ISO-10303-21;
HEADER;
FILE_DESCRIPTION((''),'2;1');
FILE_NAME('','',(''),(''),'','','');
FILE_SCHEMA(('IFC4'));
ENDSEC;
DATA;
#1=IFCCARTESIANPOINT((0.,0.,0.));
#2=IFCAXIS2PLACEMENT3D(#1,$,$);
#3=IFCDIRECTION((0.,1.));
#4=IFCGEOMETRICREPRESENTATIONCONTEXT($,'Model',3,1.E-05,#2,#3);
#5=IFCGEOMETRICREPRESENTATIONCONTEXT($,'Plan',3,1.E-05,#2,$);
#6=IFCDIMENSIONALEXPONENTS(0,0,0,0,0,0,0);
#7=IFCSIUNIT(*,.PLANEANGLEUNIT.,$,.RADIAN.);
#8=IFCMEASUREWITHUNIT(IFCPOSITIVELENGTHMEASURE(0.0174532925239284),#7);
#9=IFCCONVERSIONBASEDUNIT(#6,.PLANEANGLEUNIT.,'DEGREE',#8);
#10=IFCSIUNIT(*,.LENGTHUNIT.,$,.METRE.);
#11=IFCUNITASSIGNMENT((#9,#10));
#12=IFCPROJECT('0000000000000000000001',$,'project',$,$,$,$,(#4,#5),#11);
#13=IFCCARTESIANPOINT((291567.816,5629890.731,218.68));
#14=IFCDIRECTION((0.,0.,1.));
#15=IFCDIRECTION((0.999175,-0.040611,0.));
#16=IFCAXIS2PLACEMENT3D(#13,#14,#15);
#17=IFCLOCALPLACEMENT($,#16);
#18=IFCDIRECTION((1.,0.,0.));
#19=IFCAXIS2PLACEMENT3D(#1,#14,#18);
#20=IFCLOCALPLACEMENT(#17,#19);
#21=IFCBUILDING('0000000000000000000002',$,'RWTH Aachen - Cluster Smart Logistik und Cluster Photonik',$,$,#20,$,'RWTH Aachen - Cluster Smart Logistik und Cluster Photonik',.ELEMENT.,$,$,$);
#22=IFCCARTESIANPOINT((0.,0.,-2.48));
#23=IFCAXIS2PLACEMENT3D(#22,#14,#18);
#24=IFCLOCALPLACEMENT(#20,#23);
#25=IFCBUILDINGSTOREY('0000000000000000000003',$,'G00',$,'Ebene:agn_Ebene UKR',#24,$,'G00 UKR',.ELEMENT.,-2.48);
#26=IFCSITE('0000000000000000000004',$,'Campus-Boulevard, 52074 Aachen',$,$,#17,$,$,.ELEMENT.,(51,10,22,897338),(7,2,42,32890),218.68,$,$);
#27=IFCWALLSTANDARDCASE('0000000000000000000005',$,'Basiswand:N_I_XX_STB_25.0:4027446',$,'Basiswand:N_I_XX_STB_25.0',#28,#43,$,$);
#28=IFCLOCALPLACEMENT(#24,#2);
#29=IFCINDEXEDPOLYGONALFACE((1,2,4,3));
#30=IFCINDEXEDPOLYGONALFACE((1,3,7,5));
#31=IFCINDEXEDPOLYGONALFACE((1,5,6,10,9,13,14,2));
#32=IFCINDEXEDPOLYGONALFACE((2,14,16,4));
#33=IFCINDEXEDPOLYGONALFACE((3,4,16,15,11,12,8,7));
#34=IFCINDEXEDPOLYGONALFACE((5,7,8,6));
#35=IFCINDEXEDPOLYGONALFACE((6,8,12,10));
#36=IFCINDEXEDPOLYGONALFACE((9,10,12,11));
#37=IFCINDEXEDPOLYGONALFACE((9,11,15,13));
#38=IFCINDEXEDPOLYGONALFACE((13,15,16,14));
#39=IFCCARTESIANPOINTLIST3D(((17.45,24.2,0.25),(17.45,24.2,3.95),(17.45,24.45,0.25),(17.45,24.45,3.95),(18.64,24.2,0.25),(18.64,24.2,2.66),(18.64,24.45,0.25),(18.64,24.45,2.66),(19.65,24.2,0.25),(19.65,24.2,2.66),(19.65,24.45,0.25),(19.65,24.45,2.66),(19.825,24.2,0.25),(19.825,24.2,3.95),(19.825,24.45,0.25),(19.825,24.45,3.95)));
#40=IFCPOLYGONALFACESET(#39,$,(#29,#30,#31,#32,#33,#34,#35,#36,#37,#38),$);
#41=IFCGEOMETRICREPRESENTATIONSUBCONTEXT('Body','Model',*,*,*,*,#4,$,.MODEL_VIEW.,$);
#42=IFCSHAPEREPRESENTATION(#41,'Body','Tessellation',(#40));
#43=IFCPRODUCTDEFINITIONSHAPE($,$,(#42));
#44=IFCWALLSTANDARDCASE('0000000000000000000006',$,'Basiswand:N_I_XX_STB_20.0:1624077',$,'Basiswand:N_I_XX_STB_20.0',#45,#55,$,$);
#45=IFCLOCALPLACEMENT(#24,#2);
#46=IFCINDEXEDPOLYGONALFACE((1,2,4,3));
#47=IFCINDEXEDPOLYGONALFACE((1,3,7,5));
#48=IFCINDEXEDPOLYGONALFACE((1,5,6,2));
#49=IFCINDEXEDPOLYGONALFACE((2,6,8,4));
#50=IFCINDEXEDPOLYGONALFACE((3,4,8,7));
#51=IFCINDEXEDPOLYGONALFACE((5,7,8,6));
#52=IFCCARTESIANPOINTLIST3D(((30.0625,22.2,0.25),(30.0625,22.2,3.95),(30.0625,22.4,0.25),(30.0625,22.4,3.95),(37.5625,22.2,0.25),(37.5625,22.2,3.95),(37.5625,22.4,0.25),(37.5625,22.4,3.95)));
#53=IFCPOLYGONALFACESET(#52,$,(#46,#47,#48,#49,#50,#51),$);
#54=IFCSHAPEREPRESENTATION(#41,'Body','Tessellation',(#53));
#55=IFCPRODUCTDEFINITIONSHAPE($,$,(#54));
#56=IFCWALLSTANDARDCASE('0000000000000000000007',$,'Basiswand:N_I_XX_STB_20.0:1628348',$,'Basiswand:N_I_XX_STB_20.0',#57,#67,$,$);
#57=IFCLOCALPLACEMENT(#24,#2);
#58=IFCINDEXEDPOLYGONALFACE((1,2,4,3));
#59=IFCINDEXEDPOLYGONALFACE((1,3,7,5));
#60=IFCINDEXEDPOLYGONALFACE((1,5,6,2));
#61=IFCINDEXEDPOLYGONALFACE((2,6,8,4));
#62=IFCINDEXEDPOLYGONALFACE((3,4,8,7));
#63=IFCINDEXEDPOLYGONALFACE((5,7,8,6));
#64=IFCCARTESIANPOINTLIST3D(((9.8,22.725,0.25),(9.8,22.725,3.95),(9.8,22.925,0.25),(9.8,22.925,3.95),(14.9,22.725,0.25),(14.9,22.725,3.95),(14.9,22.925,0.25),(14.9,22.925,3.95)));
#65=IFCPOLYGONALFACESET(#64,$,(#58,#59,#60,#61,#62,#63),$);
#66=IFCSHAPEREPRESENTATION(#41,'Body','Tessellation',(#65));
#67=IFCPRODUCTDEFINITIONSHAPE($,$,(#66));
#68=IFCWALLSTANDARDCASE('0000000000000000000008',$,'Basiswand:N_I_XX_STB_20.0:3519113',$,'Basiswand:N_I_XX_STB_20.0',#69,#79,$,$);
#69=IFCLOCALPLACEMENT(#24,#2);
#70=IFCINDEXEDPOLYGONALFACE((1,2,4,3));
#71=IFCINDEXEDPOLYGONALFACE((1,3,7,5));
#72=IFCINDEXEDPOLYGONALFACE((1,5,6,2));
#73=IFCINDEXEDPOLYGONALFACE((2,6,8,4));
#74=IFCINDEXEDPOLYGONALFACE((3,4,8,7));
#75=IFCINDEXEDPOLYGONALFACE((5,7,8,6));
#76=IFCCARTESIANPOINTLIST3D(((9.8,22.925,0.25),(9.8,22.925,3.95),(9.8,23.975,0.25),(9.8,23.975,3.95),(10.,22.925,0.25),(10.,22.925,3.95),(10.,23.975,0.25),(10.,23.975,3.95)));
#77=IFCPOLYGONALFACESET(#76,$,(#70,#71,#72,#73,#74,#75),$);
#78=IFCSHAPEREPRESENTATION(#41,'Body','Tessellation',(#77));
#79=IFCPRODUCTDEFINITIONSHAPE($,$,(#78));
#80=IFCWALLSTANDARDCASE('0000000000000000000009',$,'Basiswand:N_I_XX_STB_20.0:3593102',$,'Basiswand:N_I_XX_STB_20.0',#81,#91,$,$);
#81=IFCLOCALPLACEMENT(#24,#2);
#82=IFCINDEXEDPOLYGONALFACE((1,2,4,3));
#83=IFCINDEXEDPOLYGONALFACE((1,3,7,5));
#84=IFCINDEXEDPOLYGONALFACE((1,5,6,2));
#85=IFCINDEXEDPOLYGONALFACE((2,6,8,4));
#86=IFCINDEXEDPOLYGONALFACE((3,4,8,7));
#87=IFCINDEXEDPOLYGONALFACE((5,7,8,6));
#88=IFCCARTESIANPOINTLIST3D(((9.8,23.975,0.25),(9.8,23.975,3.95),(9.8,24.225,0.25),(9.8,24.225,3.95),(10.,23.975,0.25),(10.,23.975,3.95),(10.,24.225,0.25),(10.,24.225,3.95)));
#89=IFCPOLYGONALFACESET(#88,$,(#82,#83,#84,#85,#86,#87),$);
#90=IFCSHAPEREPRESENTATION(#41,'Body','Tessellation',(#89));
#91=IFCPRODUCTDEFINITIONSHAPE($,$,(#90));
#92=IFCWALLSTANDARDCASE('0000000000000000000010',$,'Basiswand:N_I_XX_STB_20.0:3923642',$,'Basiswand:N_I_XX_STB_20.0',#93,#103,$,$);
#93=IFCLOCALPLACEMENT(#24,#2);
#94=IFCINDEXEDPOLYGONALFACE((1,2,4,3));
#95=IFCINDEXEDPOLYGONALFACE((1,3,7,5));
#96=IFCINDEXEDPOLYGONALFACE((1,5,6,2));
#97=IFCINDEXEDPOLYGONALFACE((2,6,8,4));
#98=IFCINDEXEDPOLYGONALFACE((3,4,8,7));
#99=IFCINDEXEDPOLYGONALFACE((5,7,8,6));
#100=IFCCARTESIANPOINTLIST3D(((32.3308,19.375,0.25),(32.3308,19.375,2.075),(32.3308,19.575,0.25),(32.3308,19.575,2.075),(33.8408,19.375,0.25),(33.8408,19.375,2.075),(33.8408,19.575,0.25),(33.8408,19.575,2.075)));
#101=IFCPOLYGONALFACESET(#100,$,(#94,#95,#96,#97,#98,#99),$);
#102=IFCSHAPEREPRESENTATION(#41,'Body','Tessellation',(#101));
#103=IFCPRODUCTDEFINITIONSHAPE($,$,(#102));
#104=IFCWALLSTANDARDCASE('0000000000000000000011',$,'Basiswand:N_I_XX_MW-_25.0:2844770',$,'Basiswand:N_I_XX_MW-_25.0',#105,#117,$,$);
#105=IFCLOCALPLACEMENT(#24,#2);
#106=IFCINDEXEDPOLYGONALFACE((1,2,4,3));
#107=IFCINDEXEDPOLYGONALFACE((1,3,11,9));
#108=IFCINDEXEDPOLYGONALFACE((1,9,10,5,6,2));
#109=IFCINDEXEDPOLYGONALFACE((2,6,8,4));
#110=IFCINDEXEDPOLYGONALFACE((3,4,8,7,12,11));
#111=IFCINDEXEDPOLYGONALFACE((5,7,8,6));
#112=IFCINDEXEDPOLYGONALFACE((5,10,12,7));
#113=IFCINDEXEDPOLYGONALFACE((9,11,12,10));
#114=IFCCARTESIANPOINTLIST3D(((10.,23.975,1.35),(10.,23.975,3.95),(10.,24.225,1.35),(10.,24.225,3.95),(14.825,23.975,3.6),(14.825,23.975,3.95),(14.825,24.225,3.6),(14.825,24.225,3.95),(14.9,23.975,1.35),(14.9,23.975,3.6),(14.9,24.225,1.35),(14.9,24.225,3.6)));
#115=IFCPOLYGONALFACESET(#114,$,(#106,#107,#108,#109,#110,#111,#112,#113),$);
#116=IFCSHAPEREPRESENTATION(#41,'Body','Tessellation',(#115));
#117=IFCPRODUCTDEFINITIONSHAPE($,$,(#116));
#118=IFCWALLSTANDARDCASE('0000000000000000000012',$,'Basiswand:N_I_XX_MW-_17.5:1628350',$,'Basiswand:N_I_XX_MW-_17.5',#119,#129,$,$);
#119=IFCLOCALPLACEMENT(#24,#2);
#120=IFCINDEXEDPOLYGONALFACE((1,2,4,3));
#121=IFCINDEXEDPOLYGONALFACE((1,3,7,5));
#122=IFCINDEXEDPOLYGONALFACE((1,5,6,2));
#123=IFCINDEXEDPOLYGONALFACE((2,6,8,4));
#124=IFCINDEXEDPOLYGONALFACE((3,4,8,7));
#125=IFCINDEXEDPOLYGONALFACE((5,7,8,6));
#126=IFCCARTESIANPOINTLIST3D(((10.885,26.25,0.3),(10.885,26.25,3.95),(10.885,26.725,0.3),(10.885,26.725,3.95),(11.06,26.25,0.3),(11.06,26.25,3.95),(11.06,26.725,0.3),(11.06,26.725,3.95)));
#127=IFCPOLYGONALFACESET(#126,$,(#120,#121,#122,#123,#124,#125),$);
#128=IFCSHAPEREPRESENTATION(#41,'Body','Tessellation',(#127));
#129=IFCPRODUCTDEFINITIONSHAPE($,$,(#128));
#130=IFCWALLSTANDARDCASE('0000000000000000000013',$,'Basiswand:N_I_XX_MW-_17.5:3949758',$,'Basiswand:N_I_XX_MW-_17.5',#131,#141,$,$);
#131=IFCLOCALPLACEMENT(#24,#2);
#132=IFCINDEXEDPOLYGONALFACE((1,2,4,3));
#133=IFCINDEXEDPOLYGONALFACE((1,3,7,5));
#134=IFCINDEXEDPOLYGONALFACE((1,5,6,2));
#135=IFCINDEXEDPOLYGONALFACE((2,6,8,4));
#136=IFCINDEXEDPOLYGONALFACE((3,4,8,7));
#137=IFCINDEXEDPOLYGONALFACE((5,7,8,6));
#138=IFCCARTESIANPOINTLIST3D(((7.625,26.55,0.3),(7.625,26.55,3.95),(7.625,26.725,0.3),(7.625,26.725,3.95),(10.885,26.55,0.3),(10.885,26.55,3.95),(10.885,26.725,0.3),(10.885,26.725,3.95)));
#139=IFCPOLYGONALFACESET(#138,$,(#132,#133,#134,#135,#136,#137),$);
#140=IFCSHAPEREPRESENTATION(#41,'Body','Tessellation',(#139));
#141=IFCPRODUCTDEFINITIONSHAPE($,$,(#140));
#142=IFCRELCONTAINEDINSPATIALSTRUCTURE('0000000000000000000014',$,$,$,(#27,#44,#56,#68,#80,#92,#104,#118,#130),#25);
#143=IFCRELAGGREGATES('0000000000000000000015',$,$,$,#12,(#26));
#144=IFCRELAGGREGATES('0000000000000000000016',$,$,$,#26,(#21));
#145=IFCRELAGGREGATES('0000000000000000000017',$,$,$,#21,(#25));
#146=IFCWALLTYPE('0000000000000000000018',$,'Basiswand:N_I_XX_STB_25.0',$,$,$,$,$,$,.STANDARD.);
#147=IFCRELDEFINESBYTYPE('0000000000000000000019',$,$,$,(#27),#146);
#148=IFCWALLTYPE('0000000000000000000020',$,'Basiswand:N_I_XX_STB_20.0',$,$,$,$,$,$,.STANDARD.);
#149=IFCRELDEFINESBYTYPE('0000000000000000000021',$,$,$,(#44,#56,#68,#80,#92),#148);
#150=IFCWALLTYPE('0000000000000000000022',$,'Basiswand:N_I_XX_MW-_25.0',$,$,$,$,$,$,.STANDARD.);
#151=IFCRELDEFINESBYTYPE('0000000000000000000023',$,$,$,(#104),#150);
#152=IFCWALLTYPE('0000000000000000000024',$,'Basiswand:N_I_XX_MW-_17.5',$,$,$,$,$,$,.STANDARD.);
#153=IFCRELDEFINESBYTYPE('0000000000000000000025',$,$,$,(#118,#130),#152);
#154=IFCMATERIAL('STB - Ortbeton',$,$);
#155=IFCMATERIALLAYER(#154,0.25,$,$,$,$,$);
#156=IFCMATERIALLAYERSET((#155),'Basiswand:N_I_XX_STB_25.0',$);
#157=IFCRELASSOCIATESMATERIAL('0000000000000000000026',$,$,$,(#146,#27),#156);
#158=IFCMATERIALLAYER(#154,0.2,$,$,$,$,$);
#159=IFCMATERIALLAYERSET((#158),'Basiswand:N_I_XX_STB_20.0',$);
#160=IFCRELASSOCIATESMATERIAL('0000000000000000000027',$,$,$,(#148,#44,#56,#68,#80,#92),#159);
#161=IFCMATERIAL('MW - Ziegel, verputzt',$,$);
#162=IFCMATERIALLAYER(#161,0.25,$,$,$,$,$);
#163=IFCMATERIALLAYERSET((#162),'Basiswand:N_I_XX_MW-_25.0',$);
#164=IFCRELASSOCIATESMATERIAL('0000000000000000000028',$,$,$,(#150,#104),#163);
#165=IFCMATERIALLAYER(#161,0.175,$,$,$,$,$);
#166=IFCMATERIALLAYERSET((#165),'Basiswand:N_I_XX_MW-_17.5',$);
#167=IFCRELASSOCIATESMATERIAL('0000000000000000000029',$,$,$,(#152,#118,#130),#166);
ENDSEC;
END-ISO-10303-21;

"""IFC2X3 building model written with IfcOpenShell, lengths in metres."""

from ifc_helpers import new_model, entity, si_unit, converted_unit, direction, frame, frame_2d, origin, origin_with_axes, place, context, subcontext, project, spatial, polyline, rectangle, extrude, clip, bounded_halfspace, material, layer, layer_set, layer_usage, type_object, element, save


model = new_model("IFC2X3")

# Units and contexts
model_context = context("Model", 3, precision=1e-05, world=origin(), true_north=direction((0.0, 1.0)))
plan_context = context("Plan", 3, precision=1e-05, world=origin())
body_context = subcontext(model_context, "Body", "Model", "MODEL_VIEW")
ifc_project = project(units=[converted_unit("PLANEANGLEUNIT", "DEGREE", entity("IfcPositiveLengthMeasure", 0.0174532925239284), si_unit("PLANEANGLEUNIT", "RADIAN"), dimensions=[0, 0, 0, 0, 0, 0, 0]), si_unit("LENGTHUNIT", "METRE")], contexts=[model_context, plan_context])

# Site, building, storey
site_placement = place(None, frame((291567.816, 5629890.731, 218.68), z_axis=(0.0, 0.0, 1.0), x_axis=(0.999175, -0.040611, 0.0)))
site = spatial("IfcSite", under=ifc_project, at=site_placement, Name="Campus-Boulevard, 52074 Aachen", CompositionType="ELEMENT", RefLatitude=(51, 10, 22, 897338), RefLongitude=(7, 2, 42, 32890), RefElevation=218.68)
building_placement = place(site_placement, origin_with_axes())
building = spatial("IfcBuilding", under=site, at=building_placement, Name="RWTH Aachen - Cluster Smart Logistik und Cluster Photonik", LongName="RWTH Aachen - Cluster Smart Logistik und Cluster Photonik", CompositionType="ELEMENT")
storey_placement = place(building_placement, frame((0.0, 0.0, -2.48), z_axis=(0.0, 0.0, 1.0), x_axis=(1.0, 0.0, 0.0)))
storey = spatial("IfcBuildingStorey", under=building, at=storey_placement, Name="G00", ObjectType="Ebene:agn_Ebene UKR", LongName="G00 UKR", CompositionType="ELEMENT", Elevation=-2.48)

# Shared definitions
ifc_material_1 = material(Name="STB - Ortbeton")

# Shared definitions
ifc_layer_1 = layer(ifc_material_1, 0.25)
ifc_layer_set_1 = layer_set([ifc_layer_1], Name="Basiswand:N_I_XX_STB_25.0")
wall_type_1 = type_object("IfcWallType", Name="Basiswand:N_I_XX_STB_25.0", PredefinedType="STANDARD", material=ifc_layer_set_1)

# Wall, opening
ifc_layer_usage_1 = layer_usage(ifc_layer_set_1, "AXIS2", "NEGATIVE", 0.125)
wall_1_placement = place(storey_placement, frame((19.825, 24.325, 0.25), z_axis=(0.0, 0.0, 1.0), x_axis=(-1.0, 0.0, 0.0)))
wall_1 = element("IfcWallStandardCase", 1, at=wall_1_placement, inside=storey, type_object=wall_type_1, material=ifc_layer_usage_1, Name="Basiswand:N_I_XX_STB_25.0:4027446", ObjectType="Basiswand:N_I_XX_STB_25.0", context=body_context, shape_type="SweptSolid", body=[
    extrude(rectangle(XDim=2.375, YDim=0.25, at=frame_2d((1.1875, 0.0), x_axis=(-1.0, 0.0))), origin(), (0.0, 0.0, 1.0), 3.7),
])
opening_1_placement = place(wall_1_placement, frame((0.175, -0.125, 0.0), z_axis=(0.0, 0.0, 1.0), x_axis=(1.0, 0.0, 0.0)))
element("IfcOpeningElement", 2, at=opening_1_placement, cuts=wall_1, ObjectType="Opening", context=body_context, shape_type="SweptSolid", body=[
    extrude(rectangle(XDim=2.41, YDim=1.01, at=frame_2d((1.205, 0.505), x_axis=(1.0, 0.0))), frame((0.0, 0.0, 0.0), z_axis=(0.0, 1.0, 0.0), x_axis=(0.0, 0.0, 1.0)), (0.0, 0.0, 1.0), 0.25),
])

# Walls
ifc_layer_2 = layer(ifc_material_1, 0.2)
ifc_layer_set_2 = layer_set([ifc_layer_2], Name="Basiswand:N_I_XX_STB_20.0")
ifc_layer_usage_2 = layer_usage(ifc_layer_set_2, "AXIS2", "NEGATIVE", 0.1)
wall_type_2 = type_object("IfcWallType", Name="Basiswand:N_I_XX_STB_20.0", PredefinedType="STANDARD", material=ifc_layer_set_2)
wall_2_placement = place(storey_placement, frame((30.0625, 22.3, 0.25), z_axis=(0.0, 0.0, 1.0), x_axis=(1.0, 0.0, 0.0)))
element("IfcWallStandardCase", 3, at=wall_2_placement, inside=storey, type_object=wall_type_2, material=ifc_layer_usage_2, Name="Basiswand:N_I_XX_STB_20.0:1624077", ObjectType="Basiswand:N_I_XX_STB_20.0", context=body_context, shape_type="SweptSolid", body=[
    extrude(rectangle(XDim=7.5, YDim=0.2, at=frame_2d((3.75, 0.0), x_axis=(-1.0, 0.0))), origin(), (0.0, 0.0, 1.0), 3.7),
])
ifc_layer_usage_3 = layer_usage(ifc_layer_set_2, "AXIS2", "NEGATIVE", 0.1)
wall_3_placement = place(storey_placement, frame((14.9, 22.825, 0.25), z_axis=(0.0, 0.0, 1.0), x_axis=(-1.0, 0.0, 0.0)))
element("IfcWallStandardCase", 4, at=wall_3_placement, inside=storey, type_object=wall_type_2, material=ifc_layer_usage_3, Name="Basiswand:N_I_XX_STB_20.0:1628348", ObjectType="Basiswand:N_I_XX_STB_20.0", context=body_context, shape_type="SweptSolid", body=[
    extrude(rectangle(XDim=5.1, YDim=0.2, at=frame_2d((2.55, 0.0), x_axis=(-1.0, 0.0))), origin(), (0.0, 0.0, 1.0), 3.7),
])
ifc_layer_usage_4 = layer_usage(ifc_layer_set_2, "AXIS2", "NEGATIVE", 0.1)
wall_4_placement = place(storey_placement, frame((9.9, 23.975, 0.25), z_axis=(0.0, 0.0, 1.0), x_axis=(0.0, -1.0, 0.0)))
element("IfcWallStandardCase", 5, at=wall_4_placement, inside=storey, type_object=wall_type_2, material=ifc_layer_usage_4, Name="Basiswand:N_I_XX_STB_20.0:3519113", ObjectType="Basiswand:N_I_XX_STB_20.0", context=body_context, shape_type="SweptSolid", body=[
    extrude(rectangle(XDim=1.05, YDim=0.2, at=frame_2d((0.525, 0.0), x_axis=(-1.0, 0.0))), origin(), (0.0, 0.0, 1.0), 3.7),
])
ifc_layer_usage_5 = layer_usage(ifc_layer_set_2, "AXIS2", "NEGATIVE", 0.1)
wall_5_placement = place(storey_placement, frame((9.9, 24.225, 0.25), z_axis=(0.0, 0.0, 1.0), x_axis=(0.0, -1.0, 0.0)))
element("IfcWallStandardCase", 6, at=wall_5_placement, inside=storey, type_object=wall_type_2, material=ifc_layer_usage_5, Name="Basiswand:N_I_XX_STB_20.0:3593102", ObjectType="Basiswand:N_I_XX_STB_20.0", context=body_context, shape_type="SweptSolid", body=[
    extrude(rectangle(XDim=0.25, YDim=0.2, at=frame_2d((0.125, 0.0), x_axis=(-1.0, 0.0))), origin(), (0.0, 0.0, 1.0), 3.7),
])
ifc_layer_usage_6 = layer_usage(ifc_layer_set_2, "AXIS2", "NEGATIVE", 0.1)
wall_6_placement = place(storey_placement, frame((32.3308, 19.475, 0.25), z_axis=(0.0, 0.0, 1.0), x_axis=(1.0, 0.0, 0.0)))
element("IfcWallStandardCase", 7, at=wall_6_placement, inside=storey, type_object=wall_type_2, material=ifc_layer_usage_6, Name="Basiswand:N_I_XX_STB_20.0:3923642", ObjectType="Basiswand:N_I_XX_STB_20.0", context=body_context, shape_type="SweptSolid", body=[
    extrude(rectangle(XDim=1.51, YDim=0.2, at=frame_2d((0.755, 0.0), x_axis=(-1.0, 0.0))), origin(), (0.0, 0.0, 1.0), 1.825),
])
ifc_material_2 = material(Name="MW - Ziegel, verputzt")
ifc_layer_3 = layer(ifc_material_2, 0.25)
ifc_layer_set_3 = layer_set([ifc_layer_3], Name="Basiswand:N_I_XX_MW-_25.0")
ifc_layer_usage_7 = layer_usage(ifc_layer_set_3, "AXIS2", "NEGATIVE", 0.125)
wall_type_3 = type_object("IfcWallType", Name="Basiswand:N_I_XX_MW-_25.0", PredefinedType="STANDARD", material=ifc_layer_set_3)
wall_7_placement = place(storey_placement, frame((10.0, 24.1, 1.35), z_axis=(0.0, 0.0, 1.0), x_axis=(1.0, 0.0, 0.0)))
element("IfcWallStandardCase", 8, at=wall_7_placement, inside=storey, type_object=wall_type_3, material=ifc_layer_usage_7, Name="Basiswand:N_I_XX_MW-_25.0:2844770", ObjectType="Basiswand:N_I_XX_MW-_25.0", context=body_context, shape_type="Clipping", body=[
    clip(clip(extrude(rectangle(XDim=4.9, YDim=0.25, at=frame_2d((2.45, 0.0), x_axis=(-1.0, 0.0))), origin(), (0.0, 0.0, 1.0), 2.6), bounded_halfspace(frame((4.825, 0.125, 2.25), z_axis=(0.0, 0.0, -1.0), x_axis=(0.0, -1.0, 0.0)), True, frame((4.825, 0.125, 2.25), z_axis=(0.0, 0.0, -1.0), x_axis=(0.0, -1.0, 0.0)), polyline([(0.0, 0.0), (0.0, -0.075), (0.25, -0.075), (0.25, 0.0), (0.0, 0.0)]))), bounded_halfspace(frame((4.825, -0.125, 2.25), z_axis=(-1.0, 0.0, 0.0), x_axis=(0.0, -1.0, 0.0)), True, frame((4.825, -0.125, 2.25), z_axis=(-1.0, 0.0, 0.0), x_axis=(0.0, -1.0, 0.0)), polyline([(0.0, 0.0), (0.0, 0.35), (-0.25, 0.35), (-0.25, 0.0), (0.0, 0.0)]))),
])
ifc_layer_4 = layer(ifc_material_2, 0.175)
ifc_layer_set_4 = layer_set([ifc_layer_4], Name="Basiswand:N_I_XX_MW-_17.5")
ifc_layer_usage_8 = layer_usage(ifc_layer_set_4, "AXIS2", "NEGATIVE", 0.0875)
wall_type_4 = type_object("IfcWallType", Name="Basiswand:N_I_XX_MW-_17.5", PredefinedType="STANDARD", material=ifc_layer_set_4)
wall_8_placement = place(storey_placement, frame((10.9725, 26.725, 0.3), z_axis=(0.0, 0.0, 1.0), x_axis=(0.0, -1.0, 0.0)))
element("IfcWallStandardCase", 9, at=wall_8_placement, inside=storey, type_object=wall_type_4, material=ifc_layer_usage_8, Name="Basiswand:N_I_XX_MW-_17.5:1628350", ObjectType="Basiswand:N_I_XX_MW-_17.5", context=body_context, shape_type="SweptSolid", body=[
    extrude(rectangle(XDim=0.475, YDim=0.175, at=frame_2d((0.2375, 0.0), x_axis=(-1.0, 0.0))), origin(), (0.0, 0.0, 1.0), 3.65),
])
ifc_layer_usage_9 = layer_usage(ifc_layer_set_4, "AXIS2", "NEGATIVE", 0.0875)
wall_9_placement = place(storey_placement, frame((7.625, 26.6375, 0.3), z_axis=(0.0, 0.0, 1.0), x_axis=(1.0, 0.0, 0.0)))
element("IfcWallStandardCase", 10, at=wall_9_placement, inside=storey, type_object=wall_type_4, material=ifc_layer_usage_9, Name="Basiswand:N_I_XX_MW-_17.5:3949758", ObjectType="Basiswand:N_I_XX_MW-_17.5", context=body_context, shape_type="SweptSolid", body=[
    extrude(rectangle(XDim=3.26, YDim=0.175, at=frame_2d((1.63, 0.0), x_axis=(-1.0, 0.0))), origin(), (0.0, 0.0, 1.0), 3.65),
])

save(model, "model.ifc")
